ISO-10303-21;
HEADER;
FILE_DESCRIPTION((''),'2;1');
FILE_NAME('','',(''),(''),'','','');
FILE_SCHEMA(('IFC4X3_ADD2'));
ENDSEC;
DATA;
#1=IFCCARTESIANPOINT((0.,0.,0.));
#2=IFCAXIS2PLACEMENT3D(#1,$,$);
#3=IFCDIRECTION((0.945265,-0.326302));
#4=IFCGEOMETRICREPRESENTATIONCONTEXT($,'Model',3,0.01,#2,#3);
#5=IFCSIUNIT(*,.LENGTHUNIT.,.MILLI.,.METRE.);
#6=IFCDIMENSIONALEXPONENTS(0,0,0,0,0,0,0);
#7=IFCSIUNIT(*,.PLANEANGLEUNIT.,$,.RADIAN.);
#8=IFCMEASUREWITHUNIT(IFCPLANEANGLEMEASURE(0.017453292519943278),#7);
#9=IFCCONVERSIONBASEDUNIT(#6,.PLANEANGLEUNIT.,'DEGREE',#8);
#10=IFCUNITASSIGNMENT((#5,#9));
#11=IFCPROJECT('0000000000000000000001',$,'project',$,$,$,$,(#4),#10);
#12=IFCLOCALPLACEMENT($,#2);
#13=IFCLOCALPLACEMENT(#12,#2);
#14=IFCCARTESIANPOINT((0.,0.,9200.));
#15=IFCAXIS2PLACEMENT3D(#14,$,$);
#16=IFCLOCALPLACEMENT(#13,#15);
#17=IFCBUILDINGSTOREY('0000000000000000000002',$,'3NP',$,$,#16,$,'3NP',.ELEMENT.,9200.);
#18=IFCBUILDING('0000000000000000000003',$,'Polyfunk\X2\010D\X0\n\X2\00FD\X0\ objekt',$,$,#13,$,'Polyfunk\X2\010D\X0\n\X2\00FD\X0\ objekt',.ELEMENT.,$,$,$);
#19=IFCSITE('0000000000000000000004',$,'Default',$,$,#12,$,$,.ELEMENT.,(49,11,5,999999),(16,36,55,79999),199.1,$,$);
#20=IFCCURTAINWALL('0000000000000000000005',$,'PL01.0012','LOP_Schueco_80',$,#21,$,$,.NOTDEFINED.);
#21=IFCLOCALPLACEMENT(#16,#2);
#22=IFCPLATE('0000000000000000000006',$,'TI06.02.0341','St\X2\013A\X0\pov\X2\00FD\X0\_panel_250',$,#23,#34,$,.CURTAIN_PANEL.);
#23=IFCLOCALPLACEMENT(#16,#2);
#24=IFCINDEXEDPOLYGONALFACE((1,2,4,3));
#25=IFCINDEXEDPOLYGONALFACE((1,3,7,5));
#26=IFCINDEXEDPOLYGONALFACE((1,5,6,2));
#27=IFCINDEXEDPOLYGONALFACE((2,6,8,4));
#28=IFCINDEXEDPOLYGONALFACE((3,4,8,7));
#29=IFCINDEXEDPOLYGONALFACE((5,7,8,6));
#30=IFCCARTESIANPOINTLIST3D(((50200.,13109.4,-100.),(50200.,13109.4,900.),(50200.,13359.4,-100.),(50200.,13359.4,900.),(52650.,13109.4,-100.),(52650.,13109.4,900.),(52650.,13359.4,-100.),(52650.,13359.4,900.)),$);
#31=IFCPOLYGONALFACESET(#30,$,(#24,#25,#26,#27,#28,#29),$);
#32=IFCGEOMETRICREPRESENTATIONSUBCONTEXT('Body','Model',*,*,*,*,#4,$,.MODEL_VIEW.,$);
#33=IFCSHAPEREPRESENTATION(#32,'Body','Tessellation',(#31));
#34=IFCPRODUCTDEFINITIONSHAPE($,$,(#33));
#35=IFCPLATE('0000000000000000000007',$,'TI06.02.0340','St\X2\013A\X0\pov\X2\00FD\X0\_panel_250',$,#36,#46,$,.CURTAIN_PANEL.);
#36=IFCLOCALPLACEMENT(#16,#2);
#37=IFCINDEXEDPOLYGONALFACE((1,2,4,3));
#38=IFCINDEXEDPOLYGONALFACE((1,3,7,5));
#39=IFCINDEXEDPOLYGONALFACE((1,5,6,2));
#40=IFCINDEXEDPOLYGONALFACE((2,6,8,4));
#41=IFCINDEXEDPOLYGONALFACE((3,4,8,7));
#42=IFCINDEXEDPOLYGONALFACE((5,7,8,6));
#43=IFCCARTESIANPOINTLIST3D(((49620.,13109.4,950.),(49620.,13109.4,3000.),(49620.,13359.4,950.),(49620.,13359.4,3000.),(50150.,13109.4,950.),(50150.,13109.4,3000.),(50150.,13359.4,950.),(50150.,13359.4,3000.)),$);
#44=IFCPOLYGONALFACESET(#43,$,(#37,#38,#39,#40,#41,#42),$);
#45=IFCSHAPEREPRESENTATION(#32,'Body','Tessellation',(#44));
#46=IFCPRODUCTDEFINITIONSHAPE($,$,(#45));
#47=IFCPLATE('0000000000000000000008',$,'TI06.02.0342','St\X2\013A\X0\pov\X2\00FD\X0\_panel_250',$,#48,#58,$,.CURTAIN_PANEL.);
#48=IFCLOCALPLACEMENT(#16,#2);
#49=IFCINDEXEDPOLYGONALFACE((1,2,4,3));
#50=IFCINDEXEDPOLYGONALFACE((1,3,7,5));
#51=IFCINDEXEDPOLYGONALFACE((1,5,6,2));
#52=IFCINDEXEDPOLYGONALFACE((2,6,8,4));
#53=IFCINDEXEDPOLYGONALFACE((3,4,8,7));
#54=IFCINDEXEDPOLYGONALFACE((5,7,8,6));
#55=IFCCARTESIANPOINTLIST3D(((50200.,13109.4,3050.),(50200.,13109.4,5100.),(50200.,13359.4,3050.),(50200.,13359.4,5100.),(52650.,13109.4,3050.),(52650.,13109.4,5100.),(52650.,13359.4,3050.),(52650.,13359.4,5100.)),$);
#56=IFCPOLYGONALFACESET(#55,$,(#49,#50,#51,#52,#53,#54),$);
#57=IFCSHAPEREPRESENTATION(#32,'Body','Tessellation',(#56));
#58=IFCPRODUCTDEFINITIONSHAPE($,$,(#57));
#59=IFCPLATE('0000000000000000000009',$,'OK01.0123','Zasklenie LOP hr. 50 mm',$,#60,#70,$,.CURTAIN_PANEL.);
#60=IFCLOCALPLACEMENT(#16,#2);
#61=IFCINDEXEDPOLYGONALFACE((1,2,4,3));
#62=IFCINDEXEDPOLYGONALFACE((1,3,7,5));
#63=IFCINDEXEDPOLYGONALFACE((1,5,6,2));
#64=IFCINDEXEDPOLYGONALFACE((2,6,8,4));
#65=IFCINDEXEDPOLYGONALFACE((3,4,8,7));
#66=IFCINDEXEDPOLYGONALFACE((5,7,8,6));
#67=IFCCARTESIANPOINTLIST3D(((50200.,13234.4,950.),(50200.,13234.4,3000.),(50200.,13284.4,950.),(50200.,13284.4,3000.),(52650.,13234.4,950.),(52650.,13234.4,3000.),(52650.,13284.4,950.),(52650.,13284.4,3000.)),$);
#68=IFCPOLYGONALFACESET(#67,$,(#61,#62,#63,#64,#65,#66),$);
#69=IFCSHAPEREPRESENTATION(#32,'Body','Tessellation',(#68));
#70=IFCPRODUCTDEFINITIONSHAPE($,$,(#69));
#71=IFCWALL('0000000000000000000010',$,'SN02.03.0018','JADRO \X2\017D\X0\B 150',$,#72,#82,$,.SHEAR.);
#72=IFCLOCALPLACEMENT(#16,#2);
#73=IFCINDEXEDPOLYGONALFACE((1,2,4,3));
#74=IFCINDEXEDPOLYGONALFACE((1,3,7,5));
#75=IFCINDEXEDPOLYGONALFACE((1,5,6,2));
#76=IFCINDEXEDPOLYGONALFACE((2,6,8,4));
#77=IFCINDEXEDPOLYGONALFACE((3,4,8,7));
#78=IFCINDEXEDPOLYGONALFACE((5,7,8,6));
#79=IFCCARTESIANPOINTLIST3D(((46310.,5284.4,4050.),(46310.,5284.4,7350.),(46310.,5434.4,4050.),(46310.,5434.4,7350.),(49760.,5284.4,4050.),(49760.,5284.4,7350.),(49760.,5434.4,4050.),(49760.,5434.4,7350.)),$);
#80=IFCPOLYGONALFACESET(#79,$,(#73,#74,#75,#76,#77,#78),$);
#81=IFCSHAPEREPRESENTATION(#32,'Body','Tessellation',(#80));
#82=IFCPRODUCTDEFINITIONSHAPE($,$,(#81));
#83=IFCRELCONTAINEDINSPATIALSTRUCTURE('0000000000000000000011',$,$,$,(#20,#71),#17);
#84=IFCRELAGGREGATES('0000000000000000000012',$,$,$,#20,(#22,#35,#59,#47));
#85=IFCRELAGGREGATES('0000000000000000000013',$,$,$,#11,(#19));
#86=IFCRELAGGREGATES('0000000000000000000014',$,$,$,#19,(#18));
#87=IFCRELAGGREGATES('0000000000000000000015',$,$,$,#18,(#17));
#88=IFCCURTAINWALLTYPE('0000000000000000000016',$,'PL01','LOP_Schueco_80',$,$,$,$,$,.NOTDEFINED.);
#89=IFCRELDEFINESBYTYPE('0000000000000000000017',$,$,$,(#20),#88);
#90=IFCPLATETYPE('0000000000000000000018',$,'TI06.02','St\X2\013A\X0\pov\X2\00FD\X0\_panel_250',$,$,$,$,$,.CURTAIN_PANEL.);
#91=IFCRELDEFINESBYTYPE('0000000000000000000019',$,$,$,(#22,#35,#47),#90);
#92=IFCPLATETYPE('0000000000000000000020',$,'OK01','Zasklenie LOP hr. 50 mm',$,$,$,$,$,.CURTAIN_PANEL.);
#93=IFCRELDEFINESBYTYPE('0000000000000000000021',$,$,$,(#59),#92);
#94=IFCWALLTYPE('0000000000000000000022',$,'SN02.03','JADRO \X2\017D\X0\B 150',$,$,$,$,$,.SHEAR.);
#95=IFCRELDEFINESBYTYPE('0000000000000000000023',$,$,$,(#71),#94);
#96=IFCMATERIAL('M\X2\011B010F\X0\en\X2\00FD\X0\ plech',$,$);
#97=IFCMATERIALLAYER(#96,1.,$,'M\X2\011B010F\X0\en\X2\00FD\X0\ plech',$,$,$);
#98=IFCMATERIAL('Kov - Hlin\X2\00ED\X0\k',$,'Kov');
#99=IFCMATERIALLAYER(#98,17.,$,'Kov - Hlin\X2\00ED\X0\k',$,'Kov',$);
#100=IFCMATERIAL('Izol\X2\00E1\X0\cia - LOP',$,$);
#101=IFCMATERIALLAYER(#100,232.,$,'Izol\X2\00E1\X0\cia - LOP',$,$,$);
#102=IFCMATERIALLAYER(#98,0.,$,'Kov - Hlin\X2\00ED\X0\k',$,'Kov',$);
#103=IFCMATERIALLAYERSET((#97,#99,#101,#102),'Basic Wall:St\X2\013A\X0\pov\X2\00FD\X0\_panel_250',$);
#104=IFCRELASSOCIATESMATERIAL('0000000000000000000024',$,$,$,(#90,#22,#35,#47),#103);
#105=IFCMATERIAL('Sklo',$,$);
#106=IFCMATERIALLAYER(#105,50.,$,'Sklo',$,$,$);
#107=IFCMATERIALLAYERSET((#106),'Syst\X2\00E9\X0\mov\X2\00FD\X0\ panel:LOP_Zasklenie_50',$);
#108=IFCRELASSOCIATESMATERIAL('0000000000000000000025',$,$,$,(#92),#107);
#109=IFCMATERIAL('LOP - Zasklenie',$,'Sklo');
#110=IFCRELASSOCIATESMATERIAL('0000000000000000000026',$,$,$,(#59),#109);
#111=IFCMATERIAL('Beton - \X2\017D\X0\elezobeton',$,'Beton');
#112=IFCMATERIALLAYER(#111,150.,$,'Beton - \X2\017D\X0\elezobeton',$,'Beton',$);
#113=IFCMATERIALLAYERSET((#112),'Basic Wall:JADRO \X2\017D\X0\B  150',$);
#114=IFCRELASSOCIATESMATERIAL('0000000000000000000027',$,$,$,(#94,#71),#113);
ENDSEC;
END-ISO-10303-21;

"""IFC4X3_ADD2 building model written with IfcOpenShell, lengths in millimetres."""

from ifc_helpers import new_model, entity, si_unit, converted_unit, direction, frame, frame_2d, origin, origin_2d_with_axis, place, context, subcontext, project, spatial, rectangle, extrude, source, transform, mapped, material, layer, layer_set, layer_usage, type_object, type_shapes, element, aggregate, save


model = new_model("IFC4X3_ADD2")

# Units and contexts
model_context = context("Model", 3, precision=0.01, world=origin(), true_north=direction((0.945265, -0.326302)))
body_context = subcontext(model_context, "Body", "Model", "MODEL_VIEW")
ifc_project = project(units=[si_unit("LENGTHUNIT", "METRE", prefix="MILLI"), converted_unit("PLANEANGLEUNIT", "DEGREE", entity("IfcPlaneAngleMeasure", 0.017453292519943278), si_unit("PLANEANGLEUNIT", "RADIAN"), dimensions=[0, 0, 0, 0, 0, 0, 0])], contexts=[model_context])

# Site, building, storey
site_placement = place(None, origin())
site = spatial("IfcSite", under=ifc_project, at=site_placement, Name="Default", CompositionType="ELEMENT", RefLatitude=(49, 11, 5, 999999), RefLongitude=(16, 36, 55, 79999), RefElevation=199.1)
building_placement = place(site_placement, origin())
building = spatial("IfcBuilding", under=site, at=building_placement, Name="Polyfunkčný objekt", LongName="Polyfunkčný objekt", CompositionType="ELEMENT")
storey_placement = place(building_placement, frame((0.0, 0.0, 9200.0)))
storey = spatial("IfcBuildingStorey", under=building, at=storey_placement, Name="3NP", LongName="3NP", CompositionType="ELEMENT", Elevation=9200.0)

# Curtain wall, plates
curtain_wall_type = type_object("IfcCurtainWallType", Name="PL01", Description="LOP_Schueco_80", PredefinedType="NOTDEFINED")
curtain_wall_placement = place(storey_placement, frame((0.0, 0.0, -9200.0)))
curtain_wall = element("IfcCurtainWall", 1, at=curtain_wall_placement, inside=storey, type_object=curtain_wall_type, Name="PL01.0012", Description="LOP_Schueco_80", PredefinedType="NOTDEFINED")
ifc_material_1 = material(Name="Měďený plech")
ifc_layer_1 = layer(ifc_material_1, 1.0, Name="Měďený plech")
ifc_material_2 = material(Name="Kov - Hliník", Category="Kov")
ifc_layer_2 = layer(ifc_material_2, 17.0, Name="Kov - Hliník", Category="Kov")
ifc_material_3 = material(Name="Izolácia - LOP")
ifc_layer_3 = layer(ifc_material_3, 232.0, Name="Izolácia - LOP")
ifc_layer_4 = layer(ifc_material_2, 0.0, Name="Kov - Hliník", Category="Kov")
ifc_layer_set_1 = layer_set([ifc_layer_1, ifc_layer_2, ifc_layer_3, ifc_layer_4], Name="Basic Wall:Stĺpový_panel_250")
ifc_layer_usage_1 = layer_usage(ifc_layer_set_1, "AXIS2", "NEGATIVE", 125.0)
plate_type_1 = type_object("IfcPlateType", Name="TI06.02", Description="Stĺpový_panel_250", PredefinedType="CURTAIN_PANEL", material=ifc_layer_set_1)
plate_1_placement = place(storey_placement, frame((50200.0, 13234.4, -100.0)))
plate_1 = element("IfcPlate", 2, at=plate_1_placement, type_object=plate_type_1, material=ifc_layer_usage_1, Name="TI06.02.0341", Description="Stĺpový_panel_250", PredefinedType="CURTAIN_PANEL", context=body_context, shape_type="SweptSolid", body=[
    extrude(rectangle(XDim=250.0, YDim=2450.0, at=origin_2d_with_axis()), frame((1225.0, 0.0, 0.0), z_axis=(0.0, 0.0, 1.0), x_axis=(0.0, 1.0, 0.0)), (0.0, 0.0, 1.0), 1000.0),
])
ifc_layer_usage_2 = layer_usage(ifc_layer_set_1, "AXIS2", "NEGATIVE", 125.0)
plate_2_placement = place(storey_placement, frame((49620.0, 13234.4, 950.0)))
plate_2 = element("IfcPlate", 3, at=plate_2_placement, type_object=plate_type_1, material=ifc_layer_usage_2, Name="TI06.02.0340", Description="Stĺpový_panel_250", PredefinedType="CURTAIN_PANEL", context=body_context, shape_type="SweptSolid", body=[
    extrude(rectangle(XDim=250.0, YDim=530.0, at=frame_2d((0.0, 0.0), x_axis=(1.0, 0.0))), frame((265.0, 0.0, 0.0), z_axis=(0.0, 0.0, 1.0), x_axis=(0.0, 1.0, 0.0)), (0.0, 0.0, 1.0), 2050.0),
])
ifc_layer_usage_3 = layer_usage(ifc_layer_set_1, "AXIS2", "NEGATIVE", 125.0)
plate_3_placement = place(storey_placement, frame((50200.0, 13234.4, 3050.0)))
plate_3 = element("IfcPlate", 4, at=plate_3_placement, type_object=plate_type_1, material=ifc_layer_usage_3, Name="TI06.02.0342", Description="Stĺpový_panel_250", PredefinedType="CURTAIN_PANEL", context=body_context, shape_type="SweptSolid", body=[
    extrude(rectangle(XDim=250.0, YDim=2450.0, at=origin_2d_with_axis()), frame((1225.0, 0.0, 0.0), z_axis=(0.0, 0.0, 1.0), x_axis=(0.0, 1.0, 0.0)), (0.0, 0.0, 1.0), 2050.0),
])
ifc_material_4 = material(Name="LOP - Zasklenie", Category="Sklo")
ifc_material_5 = material(Name="Sklo")
ifc_layer_5 = layer(ifc_material_5, 50.0, Name="Sklo")
ifc_layer_set_2 = layer_set([ifc_layer_5], Name="Systémový panel:LOP_Zasklenie_50")
plate_type_2 = type_object("IfcPlateType", Name="OK01", Description="Zasklenie LOP hr. 50 mm", PredefinedType="CURTAIN_PANEL", material=ifc_layer_set_2)
shared_shape_1 = source(origin(), body_context, "Body", "SweptSolid", [
    extrude(rectangle(XDim=50.0, YDim=2450.0, at=origin_2d_with_axis()), frame((0.0, 25.0, 0.0), z_axis=(0.0, 0.0, 1.0), x_axis=(0.0, 1.0, 0.0)), (0.0, 0.0, 1.0), 2050.0),
])
type_shapes(plate_type_2, [shared_shape_1])
plate_4_placement = place(curtain_wall_placement, frame((51425.0, 13234.4, 10150.0)))
plate_4 = element("IfcPlate", 5, at=plate_4_placement, type_object=plate_type_2, material=ifc_material_4, Name="OK01.0123", Description="Zasklenie LOP hr. 50 mm", PredefinedType="CURTAIN_PANEL", context=body_context, shape_type="MappedRepresentation", body=[
    mapped(shared_shape_1, transform((0.0, 0.0, 0.0), scale=1.0)),
])
aggregate(curtain_wall, [plate_1, plate_2, plate_4, plate_3])

# Wall
ifc_material_6 = material(Name="Beton - Železobeton", Category="Beton")
ifc_layer_6 = layer(ifc_material_6, 150.0, Name="Beton - Železobeton", Category="Beton")
ifc_layer_set_3 = layer_set([ifc_layer_6], Name="Basic Wall:JADRO ŽB  150")
wall_type = type_object("IfcWallType", Name="SN02.03", Description="JADRO ŽB 150", PredefinedType="SHEAR", material=ifc_layer_set_3)
wall_placement = place(storey_placement, frame((46310.0, 5359.4, 4050.0)))
element("IfcWall", 6, at=wall_placement, inside=storey, type_object=wall_type, material=ifc_layer_set_3, Name="SN02.03.0018", Description="JADRO ŽB 150", PredefinedType="SHEAR", context=body_context, shape_type="SweptSolid", body=[
    extrude(rectangle(XDim=3450.0, YDim=150.0, at=frame_2d((1725.0, 0.0), x_axis=(-1.0, 0.0))), origin(), (0.0, 0.0, 1.0), 3300.0),
])

save(model, "model.ifc")
